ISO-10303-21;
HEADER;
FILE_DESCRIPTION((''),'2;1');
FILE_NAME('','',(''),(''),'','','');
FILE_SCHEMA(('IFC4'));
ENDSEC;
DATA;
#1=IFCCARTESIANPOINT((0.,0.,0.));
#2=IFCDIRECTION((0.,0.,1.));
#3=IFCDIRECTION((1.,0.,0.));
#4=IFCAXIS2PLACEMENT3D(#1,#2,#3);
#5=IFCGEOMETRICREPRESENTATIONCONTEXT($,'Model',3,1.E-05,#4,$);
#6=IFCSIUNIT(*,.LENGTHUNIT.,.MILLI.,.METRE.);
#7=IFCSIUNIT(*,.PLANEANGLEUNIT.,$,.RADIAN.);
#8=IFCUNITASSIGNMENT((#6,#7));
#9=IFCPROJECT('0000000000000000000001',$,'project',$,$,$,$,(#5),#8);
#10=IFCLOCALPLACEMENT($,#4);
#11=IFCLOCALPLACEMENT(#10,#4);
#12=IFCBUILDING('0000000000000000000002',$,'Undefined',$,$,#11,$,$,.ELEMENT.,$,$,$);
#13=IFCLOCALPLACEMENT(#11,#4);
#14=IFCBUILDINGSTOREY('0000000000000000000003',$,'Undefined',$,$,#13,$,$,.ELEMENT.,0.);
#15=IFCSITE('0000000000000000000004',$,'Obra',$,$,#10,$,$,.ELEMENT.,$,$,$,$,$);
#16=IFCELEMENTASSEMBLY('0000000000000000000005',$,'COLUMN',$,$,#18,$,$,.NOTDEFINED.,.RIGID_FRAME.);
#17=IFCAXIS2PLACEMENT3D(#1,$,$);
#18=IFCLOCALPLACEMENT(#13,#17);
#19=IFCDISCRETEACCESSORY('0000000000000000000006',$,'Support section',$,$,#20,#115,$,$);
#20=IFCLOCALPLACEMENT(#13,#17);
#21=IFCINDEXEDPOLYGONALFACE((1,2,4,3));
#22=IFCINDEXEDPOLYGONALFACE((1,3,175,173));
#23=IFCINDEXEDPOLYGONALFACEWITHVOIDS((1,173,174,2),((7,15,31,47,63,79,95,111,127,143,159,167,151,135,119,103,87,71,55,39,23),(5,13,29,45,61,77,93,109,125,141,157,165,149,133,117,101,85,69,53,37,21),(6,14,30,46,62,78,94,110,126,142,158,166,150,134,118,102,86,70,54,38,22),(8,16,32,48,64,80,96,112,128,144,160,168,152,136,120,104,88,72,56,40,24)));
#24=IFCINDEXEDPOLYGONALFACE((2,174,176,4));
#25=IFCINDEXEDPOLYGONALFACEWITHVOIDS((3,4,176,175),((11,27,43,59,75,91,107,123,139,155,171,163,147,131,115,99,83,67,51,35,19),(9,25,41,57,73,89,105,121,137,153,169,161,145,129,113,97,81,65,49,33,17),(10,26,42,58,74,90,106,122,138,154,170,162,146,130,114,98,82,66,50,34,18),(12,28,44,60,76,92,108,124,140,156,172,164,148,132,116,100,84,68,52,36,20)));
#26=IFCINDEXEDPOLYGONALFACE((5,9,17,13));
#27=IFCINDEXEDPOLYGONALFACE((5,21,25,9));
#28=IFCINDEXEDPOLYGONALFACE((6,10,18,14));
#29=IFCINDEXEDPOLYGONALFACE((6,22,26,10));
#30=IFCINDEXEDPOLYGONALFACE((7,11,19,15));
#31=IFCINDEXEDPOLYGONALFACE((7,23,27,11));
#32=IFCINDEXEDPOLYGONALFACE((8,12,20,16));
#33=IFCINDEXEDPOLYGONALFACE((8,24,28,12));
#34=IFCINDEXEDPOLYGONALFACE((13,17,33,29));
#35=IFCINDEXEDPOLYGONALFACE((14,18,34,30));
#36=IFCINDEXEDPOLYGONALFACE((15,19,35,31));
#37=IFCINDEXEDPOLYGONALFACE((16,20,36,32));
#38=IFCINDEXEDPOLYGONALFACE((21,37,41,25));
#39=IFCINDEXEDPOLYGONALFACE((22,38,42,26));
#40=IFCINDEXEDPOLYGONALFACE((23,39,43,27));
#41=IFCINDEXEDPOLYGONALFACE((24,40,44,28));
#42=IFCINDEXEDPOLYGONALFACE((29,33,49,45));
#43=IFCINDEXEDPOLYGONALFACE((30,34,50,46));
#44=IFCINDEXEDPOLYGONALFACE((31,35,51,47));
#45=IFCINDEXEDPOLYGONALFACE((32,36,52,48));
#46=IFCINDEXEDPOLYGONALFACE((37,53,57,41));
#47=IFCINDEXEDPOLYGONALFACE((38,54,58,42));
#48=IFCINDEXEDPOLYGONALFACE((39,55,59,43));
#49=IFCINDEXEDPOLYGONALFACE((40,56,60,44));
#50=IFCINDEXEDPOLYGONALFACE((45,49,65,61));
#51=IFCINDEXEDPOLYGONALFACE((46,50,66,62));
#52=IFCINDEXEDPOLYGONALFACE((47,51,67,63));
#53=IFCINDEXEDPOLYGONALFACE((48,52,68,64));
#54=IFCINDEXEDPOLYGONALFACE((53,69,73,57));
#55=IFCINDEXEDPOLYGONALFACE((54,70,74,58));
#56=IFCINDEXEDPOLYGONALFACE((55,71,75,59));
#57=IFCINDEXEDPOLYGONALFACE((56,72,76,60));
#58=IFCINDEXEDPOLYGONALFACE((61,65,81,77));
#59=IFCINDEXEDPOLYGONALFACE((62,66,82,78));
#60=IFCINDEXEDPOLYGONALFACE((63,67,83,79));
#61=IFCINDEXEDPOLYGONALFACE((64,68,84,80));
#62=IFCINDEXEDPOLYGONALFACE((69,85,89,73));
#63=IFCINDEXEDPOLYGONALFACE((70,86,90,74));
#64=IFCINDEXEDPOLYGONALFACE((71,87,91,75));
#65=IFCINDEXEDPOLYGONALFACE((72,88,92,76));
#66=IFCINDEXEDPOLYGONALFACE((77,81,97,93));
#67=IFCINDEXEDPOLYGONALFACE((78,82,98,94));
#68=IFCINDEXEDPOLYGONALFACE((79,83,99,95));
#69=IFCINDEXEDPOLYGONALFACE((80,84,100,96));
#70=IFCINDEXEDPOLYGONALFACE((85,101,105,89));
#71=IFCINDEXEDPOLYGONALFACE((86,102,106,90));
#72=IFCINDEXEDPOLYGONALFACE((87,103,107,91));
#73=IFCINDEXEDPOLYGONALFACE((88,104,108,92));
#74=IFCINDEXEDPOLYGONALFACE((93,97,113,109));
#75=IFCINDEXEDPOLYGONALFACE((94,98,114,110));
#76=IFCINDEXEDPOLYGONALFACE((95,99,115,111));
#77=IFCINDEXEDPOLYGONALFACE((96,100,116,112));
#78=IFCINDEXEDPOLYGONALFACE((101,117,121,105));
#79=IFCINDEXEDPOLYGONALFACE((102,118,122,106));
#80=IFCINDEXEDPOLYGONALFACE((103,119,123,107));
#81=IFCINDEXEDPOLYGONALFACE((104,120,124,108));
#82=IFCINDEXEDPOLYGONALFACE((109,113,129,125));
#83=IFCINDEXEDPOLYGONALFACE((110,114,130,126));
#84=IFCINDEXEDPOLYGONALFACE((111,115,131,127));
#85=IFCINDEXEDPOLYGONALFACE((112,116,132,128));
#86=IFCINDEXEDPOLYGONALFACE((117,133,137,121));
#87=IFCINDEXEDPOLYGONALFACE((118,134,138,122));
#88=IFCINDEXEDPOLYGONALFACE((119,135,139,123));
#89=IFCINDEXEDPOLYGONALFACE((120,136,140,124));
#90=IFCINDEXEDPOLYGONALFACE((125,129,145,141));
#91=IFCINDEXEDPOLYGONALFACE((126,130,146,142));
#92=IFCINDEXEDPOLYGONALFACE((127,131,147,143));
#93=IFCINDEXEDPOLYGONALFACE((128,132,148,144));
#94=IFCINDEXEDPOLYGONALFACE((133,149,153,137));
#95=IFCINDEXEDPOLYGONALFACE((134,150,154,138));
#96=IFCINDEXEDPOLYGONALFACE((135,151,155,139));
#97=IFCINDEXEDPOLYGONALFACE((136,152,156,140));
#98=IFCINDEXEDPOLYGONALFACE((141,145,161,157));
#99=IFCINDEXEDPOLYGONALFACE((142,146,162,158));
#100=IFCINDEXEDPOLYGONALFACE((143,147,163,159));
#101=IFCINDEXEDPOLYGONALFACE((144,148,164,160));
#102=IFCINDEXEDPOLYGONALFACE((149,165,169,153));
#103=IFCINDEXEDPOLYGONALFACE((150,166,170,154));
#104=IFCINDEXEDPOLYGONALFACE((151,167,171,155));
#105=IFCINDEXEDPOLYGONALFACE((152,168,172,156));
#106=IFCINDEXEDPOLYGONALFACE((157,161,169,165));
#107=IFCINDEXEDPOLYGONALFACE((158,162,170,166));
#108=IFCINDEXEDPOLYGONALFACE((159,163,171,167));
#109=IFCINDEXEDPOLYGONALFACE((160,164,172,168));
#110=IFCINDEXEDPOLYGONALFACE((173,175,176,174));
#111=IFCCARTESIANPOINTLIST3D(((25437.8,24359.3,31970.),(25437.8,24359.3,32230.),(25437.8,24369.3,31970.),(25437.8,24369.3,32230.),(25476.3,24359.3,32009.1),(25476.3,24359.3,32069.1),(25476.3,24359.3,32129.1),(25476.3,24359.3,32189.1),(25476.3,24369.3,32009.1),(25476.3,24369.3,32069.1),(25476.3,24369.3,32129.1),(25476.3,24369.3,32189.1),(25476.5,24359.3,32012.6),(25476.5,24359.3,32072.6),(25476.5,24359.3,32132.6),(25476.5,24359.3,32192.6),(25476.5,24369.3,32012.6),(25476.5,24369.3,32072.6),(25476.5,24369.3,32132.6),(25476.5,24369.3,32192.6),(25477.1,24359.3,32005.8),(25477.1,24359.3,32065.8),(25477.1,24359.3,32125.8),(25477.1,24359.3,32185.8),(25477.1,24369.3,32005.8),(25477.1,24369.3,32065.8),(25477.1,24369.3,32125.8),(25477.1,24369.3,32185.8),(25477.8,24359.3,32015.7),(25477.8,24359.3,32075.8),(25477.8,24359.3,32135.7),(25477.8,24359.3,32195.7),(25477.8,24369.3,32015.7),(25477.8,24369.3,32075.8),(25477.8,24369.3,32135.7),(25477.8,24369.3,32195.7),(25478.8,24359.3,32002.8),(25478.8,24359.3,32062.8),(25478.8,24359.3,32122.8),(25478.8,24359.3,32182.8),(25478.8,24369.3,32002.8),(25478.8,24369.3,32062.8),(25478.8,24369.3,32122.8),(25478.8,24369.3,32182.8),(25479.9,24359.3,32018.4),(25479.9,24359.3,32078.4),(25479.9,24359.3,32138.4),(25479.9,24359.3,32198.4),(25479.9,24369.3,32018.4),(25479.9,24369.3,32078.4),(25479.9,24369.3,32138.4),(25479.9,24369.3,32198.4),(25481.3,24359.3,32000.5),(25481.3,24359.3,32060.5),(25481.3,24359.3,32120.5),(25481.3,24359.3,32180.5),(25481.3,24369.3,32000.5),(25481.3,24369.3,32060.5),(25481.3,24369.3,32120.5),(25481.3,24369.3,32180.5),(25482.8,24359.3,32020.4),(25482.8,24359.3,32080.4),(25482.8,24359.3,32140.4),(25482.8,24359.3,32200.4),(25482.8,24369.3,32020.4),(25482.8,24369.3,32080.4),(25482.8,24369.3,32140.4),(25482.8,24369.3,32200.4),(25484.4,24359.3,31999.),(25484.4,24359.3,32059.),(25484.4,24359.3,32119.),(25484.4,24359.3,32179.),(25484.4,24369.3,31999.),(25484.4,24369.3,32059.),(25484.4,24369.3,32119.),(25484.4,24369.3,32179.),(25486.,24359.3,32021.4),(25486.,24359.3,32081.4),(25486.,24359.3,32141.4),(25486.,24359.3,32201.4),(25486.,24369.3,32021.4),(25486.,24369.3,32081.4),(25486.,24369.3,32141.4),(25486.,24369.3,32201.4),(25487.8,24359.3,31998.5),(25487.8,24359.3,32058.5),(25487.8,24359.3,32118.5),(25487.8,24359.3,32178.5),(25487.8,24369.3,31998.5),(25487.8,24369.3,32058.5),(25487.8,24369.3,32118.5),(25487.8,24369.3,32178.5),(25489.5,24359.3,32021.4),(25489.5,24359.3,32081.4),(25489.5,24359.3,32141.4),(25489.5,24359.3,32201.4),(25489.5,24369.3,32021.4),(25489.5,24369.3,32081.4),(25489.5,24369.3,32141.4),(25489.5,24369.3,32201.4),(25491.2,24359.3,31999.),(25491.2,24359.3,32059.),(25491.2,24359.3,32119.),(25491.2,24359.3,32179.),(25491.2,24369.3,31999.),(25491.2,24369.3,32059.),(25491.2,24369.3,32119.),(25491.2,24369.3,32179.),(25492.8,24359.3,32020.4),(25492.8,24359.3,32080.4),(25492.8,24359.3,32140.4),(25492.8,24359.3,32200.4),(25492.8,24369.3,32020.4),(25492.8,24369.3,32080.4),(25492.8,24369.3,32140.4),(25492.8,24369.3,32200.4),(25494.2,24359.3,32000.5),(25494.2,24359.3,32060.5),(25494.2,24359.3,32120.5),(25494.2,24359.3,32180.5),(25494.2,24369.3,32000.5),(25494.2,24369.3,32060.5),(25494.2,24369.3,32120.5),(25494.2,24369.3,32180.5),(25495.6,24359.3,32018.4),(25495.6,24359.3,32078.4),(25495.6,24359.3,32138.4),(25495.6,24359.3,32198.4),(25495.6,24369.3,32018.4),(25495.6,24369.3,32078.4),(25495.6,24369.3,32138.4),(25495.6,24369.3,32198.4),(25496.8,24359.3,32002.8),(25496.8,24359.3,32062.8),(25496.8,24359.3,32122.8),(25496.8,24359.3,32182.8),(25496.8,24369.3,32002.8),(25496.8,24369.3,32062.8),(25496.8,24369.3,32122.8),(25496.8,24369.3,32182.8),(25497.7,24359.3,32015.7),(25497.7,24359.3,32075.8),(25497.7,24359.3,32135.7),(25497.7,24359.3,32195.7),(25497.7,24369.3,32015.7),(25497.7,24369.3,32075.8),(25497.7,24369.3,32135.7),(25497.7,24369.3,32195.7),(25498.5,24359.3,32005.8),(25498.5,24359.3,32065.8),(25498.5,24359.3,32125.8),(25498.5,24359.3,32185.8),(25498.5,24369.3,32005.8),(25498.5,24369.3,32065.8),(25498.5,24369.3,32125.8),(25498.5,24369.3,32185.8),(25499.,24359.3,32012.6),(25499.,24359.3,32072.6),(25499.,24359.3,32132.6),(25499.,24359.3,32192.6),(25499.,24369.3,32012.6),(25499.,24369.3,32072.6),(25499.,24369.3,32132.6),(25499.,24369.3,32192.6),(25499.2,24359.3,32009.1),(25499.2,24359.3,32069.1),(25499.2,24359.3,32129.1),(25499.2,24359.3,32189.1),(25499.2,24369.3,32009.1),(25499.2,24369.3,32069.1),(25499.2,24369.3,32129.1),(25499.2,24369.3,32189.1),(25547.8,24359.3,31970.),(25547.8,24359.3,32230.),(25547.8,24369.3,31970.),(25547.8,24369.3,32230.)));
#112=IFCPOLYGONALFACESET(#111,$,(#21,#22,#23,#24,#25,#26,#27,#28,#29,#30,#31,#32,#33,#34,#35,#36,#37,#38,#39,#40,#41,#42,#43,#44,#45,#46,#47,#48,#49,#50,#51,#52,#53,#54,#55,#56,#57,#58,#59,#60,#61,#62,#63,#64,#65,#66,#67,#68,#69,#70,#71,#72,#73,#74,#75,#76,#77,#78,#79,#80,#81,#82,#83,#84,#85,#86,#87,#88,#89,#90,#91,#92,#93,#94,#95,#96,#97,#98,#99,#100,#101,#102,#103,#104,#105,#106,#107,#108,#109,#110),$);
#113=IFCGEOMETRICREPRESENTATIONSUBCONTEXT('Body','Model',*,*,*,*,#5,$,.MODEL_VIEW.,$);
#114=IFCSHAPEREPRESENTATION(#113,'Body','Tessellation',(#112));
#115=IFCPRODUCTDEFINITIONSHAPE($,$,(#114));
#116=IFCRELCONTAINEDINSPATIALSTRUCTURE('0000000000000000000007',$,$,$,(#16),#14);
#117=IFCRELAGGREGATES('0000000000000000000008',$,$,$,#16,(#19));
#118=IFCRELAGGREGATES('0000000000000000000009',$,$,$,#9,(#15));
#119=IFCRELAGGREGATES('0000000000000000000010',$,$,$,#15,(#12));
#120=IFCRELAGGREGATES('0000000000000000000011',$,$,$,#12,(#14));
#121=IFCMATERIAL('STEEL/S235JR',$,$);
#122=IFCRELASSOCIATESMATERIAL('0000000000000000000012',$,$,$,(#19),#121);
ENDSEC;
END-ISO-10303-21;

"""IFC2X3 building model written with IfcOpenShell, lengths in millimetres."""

from ifc_helpers import new_model, si_unit, frame, origin_with_axes, origin_2d_with_axis, place, context, subcontext, project, spatial, rectangle, circle, extrude, source, transform, mapped, material, element, aggregate, save


model = new_model("IFC2X3")

# Units and contexts
model_context = context("Model", 3, precision=1e-05, world=origin_with_axes())
body_context = subcontext(model_context, "Body", "Model", "MODEL_VIEW")
ifc_project = project(units=[si_unit("LENGTHUNIT", "METRE", prefix="MILLI"), si_unit("PLANEANGLEUNIT", "RADIAN")], contexts=[model_context])

# Site, building, storey
site_placement = place(None, origin_with_axes())
site = spatial("IfcSite", under=ifc_project, at=site_placement, Name="Obra", CompositionType="ELEMENT")
building_placement = place(site_placement, origin_with_axes())
building = spatial("IfcBuilding", under=site, at=building_placement, Name="Undefined", CompositionType="ELEMENT")
storey_placement = place(building_placement, origin_with_axes())
storey = spatial("IfcBuildingStorey", under=building, at=storey_placement, Name="Undefined", CompositionType="ELEMENT", Elevation=0.0)

# Shared definitions
ifc_material_1 = material(Name="STEEL/S235JR")

# Element assembly, discrete accessory, opening
assembly_1_placement = place(storey_placement, origin_with_axes())
assembly_1 = element("IfcElementAssembly", 1, at=assembly_1_placement, inside=storey, Name="COLUMN", AssemblyPlace="NOTDEFINED", PredefinedType="RIGID_FRAME")
discrete_accessory_placement = place(assembly_1_placement, frame((25492.8, 24364.3, 31970.0), z_axis=(0.0, 0.0, 1.0), x_axis=(1.0, 0.0, 0.0)))
discrete_accessory = element("IfcDiscreteAccessory", 2, at=discrete_accessory_placement, material=ifc_material_1, Name="Support section", context=body_context, shape_type="SweptSolid", body=[
    extrude(rectangle(XDim=10.0, YDim=110.0, at=origin_2d_with_axis()), frame((0.0, 0.0, 260.0), z_axis=(0.0, 0.0, -1.0), x_axis=(0.0, 1.0, 0.0)), (0.0, 0.0, 1.0), 260.0),
])
shared_shape_1 = source(origin_with_axes(), body_context, "Body", "SweptSolid", [
    extrude(circle(Radius=11.5, at=origin_2d_with_axis()), frame((0.0, -14.4, 0.0), z_axis=(0.0, 1.0, 0.0), x_axis=(1.0, 0.0, 0.0)), (0.0, 0.0, 1.0), 10.2),
])
opening_1_placement = place(assembly_1_placement, frame((25537.8, 24355.0, 32300.0), z_axis=(-1.0, 0.0, 0.0), x_axis=(0.0, 0.0, -1.0)))
element("IfcOpeningElement", 3, at=opening_1_placement, cuts=discrete_accessory, ObjectType="Opening", context=body_context, shape_type="MappedRepresentation", body=[
    mapped(shared_shape_1, transform((110.0, 0.0, 50.0))),
    mapped(shared_shape_1, transform((170.0, 0.0, 50.0))),
    mapped(shared_shape_1, transform((230.0, 0.0, 50.0))),
    mapped(shared_shape_1, transform((290.0, 0.0, 50.0))),
])
aggregate(assembly_1, [discrete_accessory])

save(model, "model.ifc")
